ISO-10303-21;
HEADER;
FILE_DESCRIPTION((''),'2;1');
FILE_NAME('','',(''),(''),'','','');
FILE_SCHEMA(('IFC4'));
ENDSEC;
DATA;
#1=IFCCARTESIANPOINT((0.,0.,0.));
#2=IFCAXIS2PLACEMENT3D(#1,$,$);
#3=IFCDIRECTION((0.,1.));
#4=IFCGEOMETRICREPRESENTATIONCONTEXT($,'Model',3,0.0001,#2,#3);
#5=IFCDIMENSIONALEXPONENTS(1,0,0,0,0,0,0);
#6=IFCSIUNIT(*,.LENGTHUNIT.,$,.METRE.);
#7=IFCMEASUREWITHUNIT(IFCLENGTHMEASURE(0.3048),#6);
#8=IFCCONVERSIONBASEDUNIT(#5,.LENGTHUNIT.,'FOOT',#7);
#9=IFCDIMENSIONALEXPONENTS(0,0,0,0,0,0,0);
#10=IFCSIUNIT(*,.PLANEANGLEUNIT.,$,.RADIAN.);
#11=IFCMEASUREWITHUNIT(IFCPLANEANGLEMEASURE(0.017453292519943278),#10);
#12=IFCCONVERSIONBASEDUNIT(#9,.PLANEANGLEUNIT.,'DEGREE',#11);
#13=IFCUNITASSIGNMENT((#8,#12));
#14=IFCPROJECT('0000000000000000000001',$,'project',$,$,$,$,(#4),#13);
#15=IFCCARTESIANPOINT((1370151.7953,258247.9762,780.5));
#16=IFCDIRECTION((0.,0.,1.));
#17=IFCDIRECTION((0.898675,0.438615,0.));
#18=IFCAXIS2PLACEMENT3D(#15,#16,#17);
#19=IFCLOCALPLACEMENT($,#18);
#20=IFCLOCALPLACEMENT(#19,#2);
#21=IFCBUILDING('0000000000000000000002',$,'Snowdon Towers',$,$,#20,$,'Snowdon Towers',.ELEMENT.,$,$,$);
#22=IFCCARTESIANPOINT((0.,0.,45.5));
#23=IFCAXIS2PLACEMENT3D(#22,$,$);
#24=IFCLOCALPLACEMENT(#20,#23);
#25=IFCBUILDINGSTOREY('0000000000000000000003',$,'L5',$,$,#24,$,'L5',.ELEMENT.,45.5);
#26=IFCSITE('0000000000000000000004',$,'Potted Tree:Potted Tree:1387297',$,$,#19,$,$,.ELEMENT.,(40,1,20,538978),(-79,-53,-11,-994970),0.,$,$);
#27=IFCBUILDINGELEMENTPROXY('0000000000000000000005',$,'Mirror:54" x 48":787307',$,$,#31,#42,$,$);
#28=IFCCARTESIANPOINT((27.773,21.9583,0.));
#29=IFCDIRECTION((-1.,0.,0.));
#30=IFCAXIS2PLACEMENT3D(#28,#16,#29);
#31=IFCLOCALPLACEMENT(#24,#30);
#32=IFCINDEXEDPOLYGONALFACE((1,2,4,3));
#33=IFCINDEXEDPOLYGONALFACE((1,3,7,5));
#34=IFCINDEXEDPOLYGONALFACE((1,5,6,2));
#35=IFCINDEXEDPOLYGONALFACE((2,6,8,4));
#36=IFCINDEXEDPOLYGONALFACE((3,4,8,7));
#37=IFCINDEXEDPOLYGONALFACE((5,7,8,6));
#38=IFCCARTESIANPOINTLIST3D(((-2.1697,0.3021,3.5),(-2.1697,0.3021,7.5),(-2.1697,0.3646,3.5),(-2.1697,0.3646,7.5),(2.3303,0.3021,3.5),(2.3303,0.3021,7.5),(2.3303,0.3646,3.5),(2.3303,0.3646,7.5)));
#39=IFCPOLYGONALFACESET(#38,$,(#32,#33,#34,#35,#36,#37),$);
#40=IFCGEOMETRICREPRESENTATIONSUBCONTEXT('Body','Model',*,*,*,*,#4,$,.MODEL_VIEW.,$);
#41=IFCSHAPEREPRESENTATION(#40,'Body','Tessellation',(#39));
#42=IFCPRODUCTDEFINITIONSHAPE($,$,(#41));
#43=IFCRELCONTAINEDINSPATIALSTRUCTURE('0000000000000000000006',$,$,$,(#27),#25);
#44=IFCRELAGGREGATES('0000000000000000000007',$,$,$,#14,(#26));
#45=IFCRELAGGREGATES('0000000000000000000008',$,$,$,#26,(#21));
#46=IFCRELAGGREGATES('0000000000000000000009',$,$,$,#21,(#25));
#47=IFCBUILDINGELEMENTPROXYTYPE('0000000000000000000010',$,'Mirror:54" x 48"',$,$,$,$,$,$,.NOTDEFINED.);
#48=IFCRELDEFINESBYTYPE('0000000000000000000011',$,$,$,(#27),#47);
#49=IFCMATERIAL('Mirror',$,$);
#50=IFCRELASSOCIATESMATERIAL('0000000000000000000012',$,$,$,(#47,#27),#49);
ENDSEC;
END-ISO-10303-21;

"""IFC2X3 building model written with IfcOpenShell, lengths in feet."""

from ifc_helpers import new_model, entity, si_unit, converted_unit, direction, frame, origin, origin_2d_with_axis, place, context, subcontext, project, spatial, rectangle, extrude, source, transform, mapped, material, type_object, type_shapes, element, save


model = new_model("IFC2X3")

# Units and contexts
model_context = context("Model", 3, precision=0.0001, world=origin(), true_north=direction((0.0, 1.0)))
body_context = subcontext(model_context, "Body", "Model", "MODEL_VIEW")
ifc_project = project(units=[converted_unit("LENGTHUNIT", "FOOT", entity("IfcLengthMeasure", 0.3048), si_unit("LENGTHUNIT", "METRE"), dimensions=[1, 0, 0, 0, 0, 0, 0]), converted_unit("PLANEANGLEUNIT", "DEGREE", entity("IfcPlaneAngleMeasure", 0.017453292519943278), si_unit("PLANEANGLEUNIT", "RADIAN"), dimensions=[0, 0, 0, 0, 0, 0, 0])], contexts=[model_context])

# Site, building, storey
site_placement = place(None, frame((1370151.7953, 258247.9762, 780.5), z_axis=(0.0, 0.0, 1.0), x_axis=(0.898675, 0.438615, 0.0)))
site = spatial("IfcSite", under=ifc_project, at=site_placement, Name="Potted Tree:Potted Tree:1387297", CompositionType="ELEMENT", RefLatitude=(40, 1, 20, 538978), RefLongitude=(-79, -53, -11, -994970), RefElevation=0.0)
building_placement = place(site_placement, origin())
building = spatial("IfcBuilding", under=site, at=building_placement, Name="Snowdon Towers", LongName="Snowdon Towers", CompositionType="ELEMENT")
storey_placement = place(building_placement, frame((0.0, 0.0, 45.5)))
storey = spatial("IfcBuildingStorey", under=building, at=storey_placement, Name="L5", LongName="L5", CompositionType="ELEMENT", Elevation=45.5)

# Building element proxy
ifc_material_1 = material(Name="Mirror")
building_element_proxy_type_1 = type_object("IfcBuildingElementProxyType", Name="Mirror:54\" x 48\"", PredefinedType="NOTDEFINED", material=ifc_material_1)
shared_shape_1 = source(origin(), body_context, "Body", "SweptSolid", [
    extrude(rectangle(XDim=0.0625, YDim=4.5, at=origin_2d_with_axis()), frame((0.0803, 0.3333, 3.5), z_axis=(0.0, 0.0, 1.0), x_axis=(0.0, -1.0, 0.0)), (0.0, 0.0, 1.0), 4.0),
])
type_shapes(building_element_proxy_type_1, [shared_shape_1])
proxy_1_placement = place(storey_placement, frame((27.773, 21.9583, 0.0), z_axis=(0.0, 0.0, 1.0), x_axis=(-1.0, 0.0, 0.0)))
element("IfcBuildingElementProxy", 1, at=proxy_1_placement, inside=storey, type_object=building_element_proxy_type_1, material=ifc_material_1, Name="Mirror:54\" x 48\":787307", context=body_context, shape_type="MappedRepresentation", body=[
    mapped(shared_shape_1, transform((0.0, 0.0, 0.0), scale=1.0)),
])

save(model, "model.ifc")
